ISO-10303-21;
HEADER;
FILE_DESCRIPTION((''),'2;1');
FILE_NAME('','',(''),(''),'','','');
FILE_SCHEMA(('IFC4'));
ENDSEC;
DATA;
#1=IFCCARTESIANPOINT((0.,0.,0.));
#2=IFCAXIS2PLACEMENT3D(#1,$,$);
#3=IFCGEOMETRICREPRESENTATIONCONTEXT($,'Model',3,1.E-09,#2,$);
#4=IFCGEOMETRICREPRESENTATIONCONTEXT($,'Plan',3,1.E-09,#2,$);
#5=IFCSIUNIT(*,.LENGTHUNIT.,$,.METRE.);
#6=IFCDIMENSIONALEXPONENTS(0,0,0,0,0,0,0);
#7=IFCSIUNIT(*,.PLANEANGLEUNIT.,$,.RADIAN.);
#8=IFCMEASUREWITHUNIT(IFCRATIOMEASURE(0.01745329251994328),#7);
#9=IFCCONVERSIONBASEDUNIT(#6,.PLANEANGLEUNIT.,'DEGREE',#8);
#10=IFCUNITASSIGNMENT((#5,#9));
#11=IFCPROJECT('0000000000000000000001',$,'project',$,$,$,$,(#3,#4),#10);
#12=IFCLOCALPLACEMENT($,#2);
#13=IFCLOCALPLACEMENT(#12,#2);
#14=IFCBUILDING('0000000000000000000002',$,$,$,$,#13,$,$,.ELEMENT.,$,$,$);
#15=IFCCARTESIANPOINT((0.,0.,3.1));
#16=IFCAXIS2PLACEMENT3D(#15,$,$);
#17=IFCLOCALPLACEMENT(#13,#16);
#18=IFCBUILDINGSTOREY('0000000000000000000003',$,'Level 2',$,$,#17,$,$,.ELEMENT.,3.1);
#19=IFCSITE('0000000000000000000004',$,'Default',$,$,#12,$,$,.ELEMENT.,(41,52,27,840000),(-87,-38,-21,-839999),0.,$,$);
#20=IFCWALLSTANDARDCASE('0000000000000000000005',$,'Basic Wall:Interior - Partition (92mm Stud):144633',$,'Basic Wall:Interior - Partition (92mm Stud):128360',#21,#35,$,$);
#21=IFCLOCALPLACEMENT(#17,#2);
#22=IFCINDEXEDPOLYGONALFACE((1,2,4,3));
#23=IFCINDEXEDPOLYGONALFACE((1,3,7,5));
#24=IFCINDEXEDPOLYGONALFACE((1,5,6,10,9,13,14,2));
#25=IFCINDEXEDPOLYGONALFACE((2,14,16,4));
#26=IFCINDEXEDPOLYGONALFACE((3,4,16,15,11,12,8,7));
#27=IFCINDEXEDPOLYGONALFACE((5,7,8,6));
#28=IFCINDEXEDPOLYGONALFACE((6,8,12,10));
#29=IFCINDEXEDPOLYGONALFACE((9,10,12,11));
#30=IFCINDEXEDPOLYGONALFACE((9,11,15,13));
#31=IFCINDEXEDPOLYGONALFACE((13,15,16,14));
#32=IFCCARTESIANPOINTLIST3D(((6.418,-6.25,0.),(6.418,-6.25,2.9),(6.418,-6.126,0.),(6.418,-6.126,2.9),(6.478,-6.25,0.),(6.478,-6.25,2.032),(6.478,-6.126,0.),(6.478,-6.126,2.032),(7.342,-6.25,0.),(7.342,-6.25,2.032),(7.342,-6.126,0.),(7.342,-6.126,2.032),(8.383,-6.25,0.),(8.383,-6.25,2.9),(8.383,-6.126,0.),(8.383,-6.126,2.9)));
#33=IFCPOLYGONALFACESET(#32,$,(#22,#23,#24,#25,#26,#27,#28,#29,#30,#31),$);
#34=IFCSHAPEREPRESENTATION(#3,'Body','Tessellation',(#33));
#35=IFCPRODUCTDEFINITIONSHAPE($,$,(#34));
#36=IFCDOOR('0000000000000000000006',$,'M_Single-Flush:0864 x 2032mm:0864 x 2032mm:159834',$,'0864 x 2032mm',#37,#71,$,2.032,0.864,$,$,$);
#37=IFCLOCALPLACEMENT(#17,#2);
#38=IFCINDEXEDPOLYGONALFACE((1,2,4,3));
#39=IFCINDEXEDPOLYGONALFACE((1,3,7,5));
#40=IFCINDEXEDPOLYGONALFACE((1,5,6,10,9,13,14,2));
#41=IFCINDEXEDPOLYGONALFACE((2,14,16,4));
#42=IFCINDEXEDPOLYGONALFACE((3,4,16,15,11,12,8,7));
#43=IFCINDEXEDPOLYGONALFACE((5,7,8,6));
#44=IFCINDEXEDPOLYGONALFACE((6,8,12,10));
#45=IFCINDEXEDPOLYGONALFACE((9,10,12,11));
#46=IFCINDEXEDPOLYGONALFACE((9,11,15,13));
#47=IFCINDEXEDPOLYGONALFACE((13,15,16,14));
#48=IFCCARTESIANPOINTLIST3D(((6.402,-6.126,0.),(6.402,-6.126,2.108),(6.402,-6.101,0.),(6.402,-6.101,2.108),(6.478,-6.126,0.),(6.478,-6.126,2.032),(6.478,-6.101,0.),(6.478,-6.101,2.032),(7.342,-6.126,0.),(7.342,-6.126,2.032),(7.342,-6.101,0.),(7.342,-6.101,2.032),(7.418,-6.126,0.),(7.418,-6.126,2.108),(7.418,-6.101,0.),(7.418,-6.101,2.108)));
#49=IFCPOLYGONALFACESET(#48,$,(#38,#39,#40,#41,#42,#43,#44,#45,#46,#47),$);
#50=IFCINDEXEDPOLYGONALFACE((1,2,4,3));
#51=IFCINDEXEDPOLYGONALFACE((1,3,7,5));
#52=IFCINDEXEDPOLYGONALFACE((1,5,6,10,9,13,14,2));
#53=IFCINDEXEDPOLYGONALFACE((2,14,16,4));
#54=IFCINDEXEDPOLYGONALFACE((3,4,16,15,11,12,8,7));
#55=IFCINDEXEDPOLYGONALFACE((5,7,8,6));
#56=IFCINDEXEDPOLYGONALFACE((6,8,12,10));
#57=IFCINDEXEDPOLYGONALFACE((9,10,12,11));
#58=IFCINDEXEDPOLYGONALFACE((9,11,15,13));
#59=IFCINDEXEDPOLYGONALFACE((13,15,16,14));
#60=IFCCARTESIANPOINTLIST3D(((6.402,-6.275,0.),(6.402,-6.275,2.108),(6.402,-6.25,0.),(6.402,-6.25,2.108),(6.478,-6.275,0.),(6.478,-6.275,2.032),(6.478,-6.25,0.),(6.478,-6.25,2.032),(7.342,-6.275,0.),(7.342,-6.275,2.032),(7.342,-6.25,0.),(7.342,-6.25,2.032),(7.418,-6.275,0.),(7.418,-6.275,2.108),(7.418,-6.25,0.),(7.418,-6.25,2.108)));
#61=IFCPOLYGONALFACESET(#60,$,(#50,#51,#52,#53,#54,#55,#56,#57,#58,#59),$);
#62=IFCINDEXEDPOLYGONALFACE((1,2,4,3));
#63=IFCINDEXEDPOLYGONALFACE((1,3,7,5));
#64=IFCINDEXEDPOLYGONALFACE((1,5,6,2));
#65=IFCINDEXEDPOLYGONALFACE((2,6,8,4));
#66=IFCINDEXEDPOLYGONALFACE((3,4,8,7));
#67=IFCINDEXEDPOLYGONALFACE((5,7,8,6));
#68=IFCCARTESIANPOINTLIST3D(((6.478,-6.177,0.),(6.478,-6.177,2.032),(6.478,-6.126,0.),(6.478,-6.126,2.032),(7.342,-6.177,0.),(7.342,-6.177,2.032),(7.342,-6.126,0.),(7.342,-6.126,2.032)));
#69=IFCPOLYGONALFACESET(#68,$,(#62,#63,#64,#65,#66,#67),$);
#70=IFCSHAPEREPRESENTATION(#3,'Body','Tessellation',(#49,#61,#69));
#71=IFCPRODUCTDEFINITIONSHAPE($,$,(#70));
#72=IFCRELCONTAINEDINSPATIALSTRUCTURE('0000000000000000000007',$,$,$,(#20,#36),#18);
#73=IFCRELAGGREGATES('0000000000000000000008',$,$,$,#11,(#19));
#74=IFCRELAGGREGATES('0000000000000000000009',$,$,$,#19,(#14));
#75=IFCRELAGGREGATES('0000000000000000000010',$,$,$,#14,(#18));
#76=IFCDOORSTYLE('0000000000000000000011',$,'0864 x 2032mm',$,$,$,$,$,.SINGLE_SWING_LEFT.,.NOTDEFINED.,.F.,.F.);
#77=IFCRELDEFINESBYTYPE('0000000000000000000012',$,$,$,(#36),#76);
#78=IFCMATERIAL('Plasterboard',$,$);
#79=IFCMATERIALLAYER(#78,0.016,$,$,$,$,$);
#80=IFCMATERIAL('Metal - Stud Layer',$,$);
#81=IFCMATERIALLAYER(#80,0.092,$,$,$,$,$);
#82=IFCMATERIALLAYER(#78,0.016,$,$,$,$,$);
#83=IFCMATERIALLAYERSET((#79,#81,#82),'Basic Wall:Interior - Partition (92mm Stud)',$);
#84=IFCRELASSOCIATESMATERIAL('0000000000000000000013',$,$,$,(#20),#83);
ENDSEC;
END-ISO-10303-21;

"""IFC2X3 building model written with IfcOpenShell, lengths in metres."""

from ifc_helpers import new_model, entity, si_unit, converted_unit, frame, frame_2d, origin, origin_2d_with_axis, place, context, project, spatial, polyline, rectangle, outline, extrude, source, transform, mapped, material, layer, layer_set, layer_usage, type_object, type_shapes, element, fill, save


model = new_model("IFC2X3")

# Units and contexts
model_context = context("Model", 3, precision=1e-09, world=origin())
plan_context = context("Plan", 3, precision=1e-09, world=origin())
ifc_project = project(units=[si_unit("LENGTHUNIT", "METRE"), converted_unit("PLANEANGLEUNIT", "DEGREE", entity("IfcRatioMeasure", 0.01745329251994328), si_unit("PLANEANGLEUNIT", "RADIAN"), dimensions=[0, 0, 0, 0, 0, 0, 0])], contexts=[model_context, plan_context])

# Site, building, storey
site_placement = place(None, origin())
site = spatial("IfcSite", under=ifc_project, at=site_placement, Name="Default", CompositionType="ELEMENT", RefLatitude=(41, 52, 27, 840000), RefLongitude=(-87, -38, -21, -839999), RefElevation=0.0)
building_placement = place(site_placement, origin())
building = spatial("IfcBuilding", under=site, at=building_placement, CompositionType="ELEMENT")
storey_placement = place(building_placement, frame((0.0, 0.0, 3.1)))
storey = spatial("IfcBuildingStorey", under=building, at=storey_placement, Name="Level 2", CompositionType="ELEMENT", Elevation=3.1)

# Wall, opening, door
ifc_material_1 = material(Name="Plasterboard")
ifc_layer_1 = layer(ifc_material_1, 0.016)
ifc_material_2 = material(Name="Metal - Stud Layer")
ifc_layer_2 = layer(ifc_material_2, 0.092)
ifc_layer_3 = layer(ifc_material_1, 0.016)
ifc_layer_set = layer_set([ifc_layer_1, ifc_layer_2, ifc_layer_3], Name="Basic Wall:Interior - Partition (92mm Stud)")
ifc_layer_usage = layer_usage(ifc_layer_set, "AXIS2", "NEGATIVE", 0.062)
wall_placement = place(storey_placement, frame((6.418, -6.188, 0.0)))
wall = element("IfcWallStandardCase", 1, at=wall_placement, inside=storey, material=ifc_layer_usage, Name="Basic Wall:Interior - Partition (92mm Stud):144633", ObjectType="Basic Wall:Interior - Partition (92mm Stud):128360", context=model_context, shape_type="SweptSolid", body=[
    extrude(rectangle(XDim=1.965, YDim=0.124, at=frame_2d((0.9825, 0.0), x_axis=(-1.0, 0.0))), origin(), (0.0, 0.0, 1.0), 2.9),
])
opening_placement = place(wall_placement, frame((0.06, -0.062, 0.0)))
opening = element("IfcOpeningElement", 2, at=opening_placement, cuts=wall, ObjectType="Opening", context=model_context, shape_type="SweptSolid", body=[
    extrude(rectangle(XDim=0.864, YDim=2.032, at=frame_2d((1.016, 0.432), x_axis=(0.0, -1.0))), frame((0.0, 0.0, 0.0), z_axis=(0.0, 1.0, 0.0), x_axis=(0.0, 0.0, 1.0)), (0.0, 0.0, 1.0), 0.124),
])
door_style = type_object("IfcDoorStyle", Name="0864 x 2032mm", ConstructionType="NOTDEFINED", OperationType="SINGLE_SWING_LEFT", ParameterTakesPrecedence=False, Sizeable=False)
shared_shape = source(origin(), model_context, "Body", "SweptSolid", [
    extrude(outline(polyline([(-0.508, -1.073), (0.508, -1.073), (0.508, 1.035), (0.432, 1.035), (0.432, -0.997), (-0.432, -0.997), (-0.432, 1.035), (-0.508, 1.035), (-0.508, -1.073)])), frame((0.432, 0.149, 1.035), z_axis=(0.0, -1.0, 0.0), x_axis=(-1.0, 0.0, 0.0)), (0.0, 0.0, 1.0), 0.025),
    extrude(outline(polyline([(-1.073, -0.508), (1.035, -0.508), (1.035, -0.432), (-0.997, -0.432), (-0.997, 0.432), (1.035, 0.432), (1.035, 0.508), (-1.073, 0.508), (-1.073, -0.508)])), frame((0.432, 0.0, 1.035), z_axis=(0.0, -1.0, 0.0), x_axis=(0.0, 0.0, -1.0)), (0.0, 0.0, 1.0), 0.025),
    extrude(rectangle(XDim=0.864, YDim=0.051, at=origin_2d_with_axis()), frame((0.432, 0.0985, 0.0)), (0.0, 0.0, 1.0), 2.032),
])
type_shapes(door_style, [shared_shape])
door_placement = place(opening_placement, origin())
door = element("IfcDoor", 3, at=door_placement, inside=storey, type_object=door_style, Name="M_Single-Flush:0864 x 2032mm:0864 x 2032mm:159834", ObjectType="0864 x 2032mm", OverallHeight=2.032, OverallWidth=0.864, context=model_context, shape_type="MappedRepresentation", body=[
    mapped(shared_shape, transform((0.0, 0.0, 0.0), scale=1.0)),
])
fill(opening, door)

save(model, "model.ifc")
